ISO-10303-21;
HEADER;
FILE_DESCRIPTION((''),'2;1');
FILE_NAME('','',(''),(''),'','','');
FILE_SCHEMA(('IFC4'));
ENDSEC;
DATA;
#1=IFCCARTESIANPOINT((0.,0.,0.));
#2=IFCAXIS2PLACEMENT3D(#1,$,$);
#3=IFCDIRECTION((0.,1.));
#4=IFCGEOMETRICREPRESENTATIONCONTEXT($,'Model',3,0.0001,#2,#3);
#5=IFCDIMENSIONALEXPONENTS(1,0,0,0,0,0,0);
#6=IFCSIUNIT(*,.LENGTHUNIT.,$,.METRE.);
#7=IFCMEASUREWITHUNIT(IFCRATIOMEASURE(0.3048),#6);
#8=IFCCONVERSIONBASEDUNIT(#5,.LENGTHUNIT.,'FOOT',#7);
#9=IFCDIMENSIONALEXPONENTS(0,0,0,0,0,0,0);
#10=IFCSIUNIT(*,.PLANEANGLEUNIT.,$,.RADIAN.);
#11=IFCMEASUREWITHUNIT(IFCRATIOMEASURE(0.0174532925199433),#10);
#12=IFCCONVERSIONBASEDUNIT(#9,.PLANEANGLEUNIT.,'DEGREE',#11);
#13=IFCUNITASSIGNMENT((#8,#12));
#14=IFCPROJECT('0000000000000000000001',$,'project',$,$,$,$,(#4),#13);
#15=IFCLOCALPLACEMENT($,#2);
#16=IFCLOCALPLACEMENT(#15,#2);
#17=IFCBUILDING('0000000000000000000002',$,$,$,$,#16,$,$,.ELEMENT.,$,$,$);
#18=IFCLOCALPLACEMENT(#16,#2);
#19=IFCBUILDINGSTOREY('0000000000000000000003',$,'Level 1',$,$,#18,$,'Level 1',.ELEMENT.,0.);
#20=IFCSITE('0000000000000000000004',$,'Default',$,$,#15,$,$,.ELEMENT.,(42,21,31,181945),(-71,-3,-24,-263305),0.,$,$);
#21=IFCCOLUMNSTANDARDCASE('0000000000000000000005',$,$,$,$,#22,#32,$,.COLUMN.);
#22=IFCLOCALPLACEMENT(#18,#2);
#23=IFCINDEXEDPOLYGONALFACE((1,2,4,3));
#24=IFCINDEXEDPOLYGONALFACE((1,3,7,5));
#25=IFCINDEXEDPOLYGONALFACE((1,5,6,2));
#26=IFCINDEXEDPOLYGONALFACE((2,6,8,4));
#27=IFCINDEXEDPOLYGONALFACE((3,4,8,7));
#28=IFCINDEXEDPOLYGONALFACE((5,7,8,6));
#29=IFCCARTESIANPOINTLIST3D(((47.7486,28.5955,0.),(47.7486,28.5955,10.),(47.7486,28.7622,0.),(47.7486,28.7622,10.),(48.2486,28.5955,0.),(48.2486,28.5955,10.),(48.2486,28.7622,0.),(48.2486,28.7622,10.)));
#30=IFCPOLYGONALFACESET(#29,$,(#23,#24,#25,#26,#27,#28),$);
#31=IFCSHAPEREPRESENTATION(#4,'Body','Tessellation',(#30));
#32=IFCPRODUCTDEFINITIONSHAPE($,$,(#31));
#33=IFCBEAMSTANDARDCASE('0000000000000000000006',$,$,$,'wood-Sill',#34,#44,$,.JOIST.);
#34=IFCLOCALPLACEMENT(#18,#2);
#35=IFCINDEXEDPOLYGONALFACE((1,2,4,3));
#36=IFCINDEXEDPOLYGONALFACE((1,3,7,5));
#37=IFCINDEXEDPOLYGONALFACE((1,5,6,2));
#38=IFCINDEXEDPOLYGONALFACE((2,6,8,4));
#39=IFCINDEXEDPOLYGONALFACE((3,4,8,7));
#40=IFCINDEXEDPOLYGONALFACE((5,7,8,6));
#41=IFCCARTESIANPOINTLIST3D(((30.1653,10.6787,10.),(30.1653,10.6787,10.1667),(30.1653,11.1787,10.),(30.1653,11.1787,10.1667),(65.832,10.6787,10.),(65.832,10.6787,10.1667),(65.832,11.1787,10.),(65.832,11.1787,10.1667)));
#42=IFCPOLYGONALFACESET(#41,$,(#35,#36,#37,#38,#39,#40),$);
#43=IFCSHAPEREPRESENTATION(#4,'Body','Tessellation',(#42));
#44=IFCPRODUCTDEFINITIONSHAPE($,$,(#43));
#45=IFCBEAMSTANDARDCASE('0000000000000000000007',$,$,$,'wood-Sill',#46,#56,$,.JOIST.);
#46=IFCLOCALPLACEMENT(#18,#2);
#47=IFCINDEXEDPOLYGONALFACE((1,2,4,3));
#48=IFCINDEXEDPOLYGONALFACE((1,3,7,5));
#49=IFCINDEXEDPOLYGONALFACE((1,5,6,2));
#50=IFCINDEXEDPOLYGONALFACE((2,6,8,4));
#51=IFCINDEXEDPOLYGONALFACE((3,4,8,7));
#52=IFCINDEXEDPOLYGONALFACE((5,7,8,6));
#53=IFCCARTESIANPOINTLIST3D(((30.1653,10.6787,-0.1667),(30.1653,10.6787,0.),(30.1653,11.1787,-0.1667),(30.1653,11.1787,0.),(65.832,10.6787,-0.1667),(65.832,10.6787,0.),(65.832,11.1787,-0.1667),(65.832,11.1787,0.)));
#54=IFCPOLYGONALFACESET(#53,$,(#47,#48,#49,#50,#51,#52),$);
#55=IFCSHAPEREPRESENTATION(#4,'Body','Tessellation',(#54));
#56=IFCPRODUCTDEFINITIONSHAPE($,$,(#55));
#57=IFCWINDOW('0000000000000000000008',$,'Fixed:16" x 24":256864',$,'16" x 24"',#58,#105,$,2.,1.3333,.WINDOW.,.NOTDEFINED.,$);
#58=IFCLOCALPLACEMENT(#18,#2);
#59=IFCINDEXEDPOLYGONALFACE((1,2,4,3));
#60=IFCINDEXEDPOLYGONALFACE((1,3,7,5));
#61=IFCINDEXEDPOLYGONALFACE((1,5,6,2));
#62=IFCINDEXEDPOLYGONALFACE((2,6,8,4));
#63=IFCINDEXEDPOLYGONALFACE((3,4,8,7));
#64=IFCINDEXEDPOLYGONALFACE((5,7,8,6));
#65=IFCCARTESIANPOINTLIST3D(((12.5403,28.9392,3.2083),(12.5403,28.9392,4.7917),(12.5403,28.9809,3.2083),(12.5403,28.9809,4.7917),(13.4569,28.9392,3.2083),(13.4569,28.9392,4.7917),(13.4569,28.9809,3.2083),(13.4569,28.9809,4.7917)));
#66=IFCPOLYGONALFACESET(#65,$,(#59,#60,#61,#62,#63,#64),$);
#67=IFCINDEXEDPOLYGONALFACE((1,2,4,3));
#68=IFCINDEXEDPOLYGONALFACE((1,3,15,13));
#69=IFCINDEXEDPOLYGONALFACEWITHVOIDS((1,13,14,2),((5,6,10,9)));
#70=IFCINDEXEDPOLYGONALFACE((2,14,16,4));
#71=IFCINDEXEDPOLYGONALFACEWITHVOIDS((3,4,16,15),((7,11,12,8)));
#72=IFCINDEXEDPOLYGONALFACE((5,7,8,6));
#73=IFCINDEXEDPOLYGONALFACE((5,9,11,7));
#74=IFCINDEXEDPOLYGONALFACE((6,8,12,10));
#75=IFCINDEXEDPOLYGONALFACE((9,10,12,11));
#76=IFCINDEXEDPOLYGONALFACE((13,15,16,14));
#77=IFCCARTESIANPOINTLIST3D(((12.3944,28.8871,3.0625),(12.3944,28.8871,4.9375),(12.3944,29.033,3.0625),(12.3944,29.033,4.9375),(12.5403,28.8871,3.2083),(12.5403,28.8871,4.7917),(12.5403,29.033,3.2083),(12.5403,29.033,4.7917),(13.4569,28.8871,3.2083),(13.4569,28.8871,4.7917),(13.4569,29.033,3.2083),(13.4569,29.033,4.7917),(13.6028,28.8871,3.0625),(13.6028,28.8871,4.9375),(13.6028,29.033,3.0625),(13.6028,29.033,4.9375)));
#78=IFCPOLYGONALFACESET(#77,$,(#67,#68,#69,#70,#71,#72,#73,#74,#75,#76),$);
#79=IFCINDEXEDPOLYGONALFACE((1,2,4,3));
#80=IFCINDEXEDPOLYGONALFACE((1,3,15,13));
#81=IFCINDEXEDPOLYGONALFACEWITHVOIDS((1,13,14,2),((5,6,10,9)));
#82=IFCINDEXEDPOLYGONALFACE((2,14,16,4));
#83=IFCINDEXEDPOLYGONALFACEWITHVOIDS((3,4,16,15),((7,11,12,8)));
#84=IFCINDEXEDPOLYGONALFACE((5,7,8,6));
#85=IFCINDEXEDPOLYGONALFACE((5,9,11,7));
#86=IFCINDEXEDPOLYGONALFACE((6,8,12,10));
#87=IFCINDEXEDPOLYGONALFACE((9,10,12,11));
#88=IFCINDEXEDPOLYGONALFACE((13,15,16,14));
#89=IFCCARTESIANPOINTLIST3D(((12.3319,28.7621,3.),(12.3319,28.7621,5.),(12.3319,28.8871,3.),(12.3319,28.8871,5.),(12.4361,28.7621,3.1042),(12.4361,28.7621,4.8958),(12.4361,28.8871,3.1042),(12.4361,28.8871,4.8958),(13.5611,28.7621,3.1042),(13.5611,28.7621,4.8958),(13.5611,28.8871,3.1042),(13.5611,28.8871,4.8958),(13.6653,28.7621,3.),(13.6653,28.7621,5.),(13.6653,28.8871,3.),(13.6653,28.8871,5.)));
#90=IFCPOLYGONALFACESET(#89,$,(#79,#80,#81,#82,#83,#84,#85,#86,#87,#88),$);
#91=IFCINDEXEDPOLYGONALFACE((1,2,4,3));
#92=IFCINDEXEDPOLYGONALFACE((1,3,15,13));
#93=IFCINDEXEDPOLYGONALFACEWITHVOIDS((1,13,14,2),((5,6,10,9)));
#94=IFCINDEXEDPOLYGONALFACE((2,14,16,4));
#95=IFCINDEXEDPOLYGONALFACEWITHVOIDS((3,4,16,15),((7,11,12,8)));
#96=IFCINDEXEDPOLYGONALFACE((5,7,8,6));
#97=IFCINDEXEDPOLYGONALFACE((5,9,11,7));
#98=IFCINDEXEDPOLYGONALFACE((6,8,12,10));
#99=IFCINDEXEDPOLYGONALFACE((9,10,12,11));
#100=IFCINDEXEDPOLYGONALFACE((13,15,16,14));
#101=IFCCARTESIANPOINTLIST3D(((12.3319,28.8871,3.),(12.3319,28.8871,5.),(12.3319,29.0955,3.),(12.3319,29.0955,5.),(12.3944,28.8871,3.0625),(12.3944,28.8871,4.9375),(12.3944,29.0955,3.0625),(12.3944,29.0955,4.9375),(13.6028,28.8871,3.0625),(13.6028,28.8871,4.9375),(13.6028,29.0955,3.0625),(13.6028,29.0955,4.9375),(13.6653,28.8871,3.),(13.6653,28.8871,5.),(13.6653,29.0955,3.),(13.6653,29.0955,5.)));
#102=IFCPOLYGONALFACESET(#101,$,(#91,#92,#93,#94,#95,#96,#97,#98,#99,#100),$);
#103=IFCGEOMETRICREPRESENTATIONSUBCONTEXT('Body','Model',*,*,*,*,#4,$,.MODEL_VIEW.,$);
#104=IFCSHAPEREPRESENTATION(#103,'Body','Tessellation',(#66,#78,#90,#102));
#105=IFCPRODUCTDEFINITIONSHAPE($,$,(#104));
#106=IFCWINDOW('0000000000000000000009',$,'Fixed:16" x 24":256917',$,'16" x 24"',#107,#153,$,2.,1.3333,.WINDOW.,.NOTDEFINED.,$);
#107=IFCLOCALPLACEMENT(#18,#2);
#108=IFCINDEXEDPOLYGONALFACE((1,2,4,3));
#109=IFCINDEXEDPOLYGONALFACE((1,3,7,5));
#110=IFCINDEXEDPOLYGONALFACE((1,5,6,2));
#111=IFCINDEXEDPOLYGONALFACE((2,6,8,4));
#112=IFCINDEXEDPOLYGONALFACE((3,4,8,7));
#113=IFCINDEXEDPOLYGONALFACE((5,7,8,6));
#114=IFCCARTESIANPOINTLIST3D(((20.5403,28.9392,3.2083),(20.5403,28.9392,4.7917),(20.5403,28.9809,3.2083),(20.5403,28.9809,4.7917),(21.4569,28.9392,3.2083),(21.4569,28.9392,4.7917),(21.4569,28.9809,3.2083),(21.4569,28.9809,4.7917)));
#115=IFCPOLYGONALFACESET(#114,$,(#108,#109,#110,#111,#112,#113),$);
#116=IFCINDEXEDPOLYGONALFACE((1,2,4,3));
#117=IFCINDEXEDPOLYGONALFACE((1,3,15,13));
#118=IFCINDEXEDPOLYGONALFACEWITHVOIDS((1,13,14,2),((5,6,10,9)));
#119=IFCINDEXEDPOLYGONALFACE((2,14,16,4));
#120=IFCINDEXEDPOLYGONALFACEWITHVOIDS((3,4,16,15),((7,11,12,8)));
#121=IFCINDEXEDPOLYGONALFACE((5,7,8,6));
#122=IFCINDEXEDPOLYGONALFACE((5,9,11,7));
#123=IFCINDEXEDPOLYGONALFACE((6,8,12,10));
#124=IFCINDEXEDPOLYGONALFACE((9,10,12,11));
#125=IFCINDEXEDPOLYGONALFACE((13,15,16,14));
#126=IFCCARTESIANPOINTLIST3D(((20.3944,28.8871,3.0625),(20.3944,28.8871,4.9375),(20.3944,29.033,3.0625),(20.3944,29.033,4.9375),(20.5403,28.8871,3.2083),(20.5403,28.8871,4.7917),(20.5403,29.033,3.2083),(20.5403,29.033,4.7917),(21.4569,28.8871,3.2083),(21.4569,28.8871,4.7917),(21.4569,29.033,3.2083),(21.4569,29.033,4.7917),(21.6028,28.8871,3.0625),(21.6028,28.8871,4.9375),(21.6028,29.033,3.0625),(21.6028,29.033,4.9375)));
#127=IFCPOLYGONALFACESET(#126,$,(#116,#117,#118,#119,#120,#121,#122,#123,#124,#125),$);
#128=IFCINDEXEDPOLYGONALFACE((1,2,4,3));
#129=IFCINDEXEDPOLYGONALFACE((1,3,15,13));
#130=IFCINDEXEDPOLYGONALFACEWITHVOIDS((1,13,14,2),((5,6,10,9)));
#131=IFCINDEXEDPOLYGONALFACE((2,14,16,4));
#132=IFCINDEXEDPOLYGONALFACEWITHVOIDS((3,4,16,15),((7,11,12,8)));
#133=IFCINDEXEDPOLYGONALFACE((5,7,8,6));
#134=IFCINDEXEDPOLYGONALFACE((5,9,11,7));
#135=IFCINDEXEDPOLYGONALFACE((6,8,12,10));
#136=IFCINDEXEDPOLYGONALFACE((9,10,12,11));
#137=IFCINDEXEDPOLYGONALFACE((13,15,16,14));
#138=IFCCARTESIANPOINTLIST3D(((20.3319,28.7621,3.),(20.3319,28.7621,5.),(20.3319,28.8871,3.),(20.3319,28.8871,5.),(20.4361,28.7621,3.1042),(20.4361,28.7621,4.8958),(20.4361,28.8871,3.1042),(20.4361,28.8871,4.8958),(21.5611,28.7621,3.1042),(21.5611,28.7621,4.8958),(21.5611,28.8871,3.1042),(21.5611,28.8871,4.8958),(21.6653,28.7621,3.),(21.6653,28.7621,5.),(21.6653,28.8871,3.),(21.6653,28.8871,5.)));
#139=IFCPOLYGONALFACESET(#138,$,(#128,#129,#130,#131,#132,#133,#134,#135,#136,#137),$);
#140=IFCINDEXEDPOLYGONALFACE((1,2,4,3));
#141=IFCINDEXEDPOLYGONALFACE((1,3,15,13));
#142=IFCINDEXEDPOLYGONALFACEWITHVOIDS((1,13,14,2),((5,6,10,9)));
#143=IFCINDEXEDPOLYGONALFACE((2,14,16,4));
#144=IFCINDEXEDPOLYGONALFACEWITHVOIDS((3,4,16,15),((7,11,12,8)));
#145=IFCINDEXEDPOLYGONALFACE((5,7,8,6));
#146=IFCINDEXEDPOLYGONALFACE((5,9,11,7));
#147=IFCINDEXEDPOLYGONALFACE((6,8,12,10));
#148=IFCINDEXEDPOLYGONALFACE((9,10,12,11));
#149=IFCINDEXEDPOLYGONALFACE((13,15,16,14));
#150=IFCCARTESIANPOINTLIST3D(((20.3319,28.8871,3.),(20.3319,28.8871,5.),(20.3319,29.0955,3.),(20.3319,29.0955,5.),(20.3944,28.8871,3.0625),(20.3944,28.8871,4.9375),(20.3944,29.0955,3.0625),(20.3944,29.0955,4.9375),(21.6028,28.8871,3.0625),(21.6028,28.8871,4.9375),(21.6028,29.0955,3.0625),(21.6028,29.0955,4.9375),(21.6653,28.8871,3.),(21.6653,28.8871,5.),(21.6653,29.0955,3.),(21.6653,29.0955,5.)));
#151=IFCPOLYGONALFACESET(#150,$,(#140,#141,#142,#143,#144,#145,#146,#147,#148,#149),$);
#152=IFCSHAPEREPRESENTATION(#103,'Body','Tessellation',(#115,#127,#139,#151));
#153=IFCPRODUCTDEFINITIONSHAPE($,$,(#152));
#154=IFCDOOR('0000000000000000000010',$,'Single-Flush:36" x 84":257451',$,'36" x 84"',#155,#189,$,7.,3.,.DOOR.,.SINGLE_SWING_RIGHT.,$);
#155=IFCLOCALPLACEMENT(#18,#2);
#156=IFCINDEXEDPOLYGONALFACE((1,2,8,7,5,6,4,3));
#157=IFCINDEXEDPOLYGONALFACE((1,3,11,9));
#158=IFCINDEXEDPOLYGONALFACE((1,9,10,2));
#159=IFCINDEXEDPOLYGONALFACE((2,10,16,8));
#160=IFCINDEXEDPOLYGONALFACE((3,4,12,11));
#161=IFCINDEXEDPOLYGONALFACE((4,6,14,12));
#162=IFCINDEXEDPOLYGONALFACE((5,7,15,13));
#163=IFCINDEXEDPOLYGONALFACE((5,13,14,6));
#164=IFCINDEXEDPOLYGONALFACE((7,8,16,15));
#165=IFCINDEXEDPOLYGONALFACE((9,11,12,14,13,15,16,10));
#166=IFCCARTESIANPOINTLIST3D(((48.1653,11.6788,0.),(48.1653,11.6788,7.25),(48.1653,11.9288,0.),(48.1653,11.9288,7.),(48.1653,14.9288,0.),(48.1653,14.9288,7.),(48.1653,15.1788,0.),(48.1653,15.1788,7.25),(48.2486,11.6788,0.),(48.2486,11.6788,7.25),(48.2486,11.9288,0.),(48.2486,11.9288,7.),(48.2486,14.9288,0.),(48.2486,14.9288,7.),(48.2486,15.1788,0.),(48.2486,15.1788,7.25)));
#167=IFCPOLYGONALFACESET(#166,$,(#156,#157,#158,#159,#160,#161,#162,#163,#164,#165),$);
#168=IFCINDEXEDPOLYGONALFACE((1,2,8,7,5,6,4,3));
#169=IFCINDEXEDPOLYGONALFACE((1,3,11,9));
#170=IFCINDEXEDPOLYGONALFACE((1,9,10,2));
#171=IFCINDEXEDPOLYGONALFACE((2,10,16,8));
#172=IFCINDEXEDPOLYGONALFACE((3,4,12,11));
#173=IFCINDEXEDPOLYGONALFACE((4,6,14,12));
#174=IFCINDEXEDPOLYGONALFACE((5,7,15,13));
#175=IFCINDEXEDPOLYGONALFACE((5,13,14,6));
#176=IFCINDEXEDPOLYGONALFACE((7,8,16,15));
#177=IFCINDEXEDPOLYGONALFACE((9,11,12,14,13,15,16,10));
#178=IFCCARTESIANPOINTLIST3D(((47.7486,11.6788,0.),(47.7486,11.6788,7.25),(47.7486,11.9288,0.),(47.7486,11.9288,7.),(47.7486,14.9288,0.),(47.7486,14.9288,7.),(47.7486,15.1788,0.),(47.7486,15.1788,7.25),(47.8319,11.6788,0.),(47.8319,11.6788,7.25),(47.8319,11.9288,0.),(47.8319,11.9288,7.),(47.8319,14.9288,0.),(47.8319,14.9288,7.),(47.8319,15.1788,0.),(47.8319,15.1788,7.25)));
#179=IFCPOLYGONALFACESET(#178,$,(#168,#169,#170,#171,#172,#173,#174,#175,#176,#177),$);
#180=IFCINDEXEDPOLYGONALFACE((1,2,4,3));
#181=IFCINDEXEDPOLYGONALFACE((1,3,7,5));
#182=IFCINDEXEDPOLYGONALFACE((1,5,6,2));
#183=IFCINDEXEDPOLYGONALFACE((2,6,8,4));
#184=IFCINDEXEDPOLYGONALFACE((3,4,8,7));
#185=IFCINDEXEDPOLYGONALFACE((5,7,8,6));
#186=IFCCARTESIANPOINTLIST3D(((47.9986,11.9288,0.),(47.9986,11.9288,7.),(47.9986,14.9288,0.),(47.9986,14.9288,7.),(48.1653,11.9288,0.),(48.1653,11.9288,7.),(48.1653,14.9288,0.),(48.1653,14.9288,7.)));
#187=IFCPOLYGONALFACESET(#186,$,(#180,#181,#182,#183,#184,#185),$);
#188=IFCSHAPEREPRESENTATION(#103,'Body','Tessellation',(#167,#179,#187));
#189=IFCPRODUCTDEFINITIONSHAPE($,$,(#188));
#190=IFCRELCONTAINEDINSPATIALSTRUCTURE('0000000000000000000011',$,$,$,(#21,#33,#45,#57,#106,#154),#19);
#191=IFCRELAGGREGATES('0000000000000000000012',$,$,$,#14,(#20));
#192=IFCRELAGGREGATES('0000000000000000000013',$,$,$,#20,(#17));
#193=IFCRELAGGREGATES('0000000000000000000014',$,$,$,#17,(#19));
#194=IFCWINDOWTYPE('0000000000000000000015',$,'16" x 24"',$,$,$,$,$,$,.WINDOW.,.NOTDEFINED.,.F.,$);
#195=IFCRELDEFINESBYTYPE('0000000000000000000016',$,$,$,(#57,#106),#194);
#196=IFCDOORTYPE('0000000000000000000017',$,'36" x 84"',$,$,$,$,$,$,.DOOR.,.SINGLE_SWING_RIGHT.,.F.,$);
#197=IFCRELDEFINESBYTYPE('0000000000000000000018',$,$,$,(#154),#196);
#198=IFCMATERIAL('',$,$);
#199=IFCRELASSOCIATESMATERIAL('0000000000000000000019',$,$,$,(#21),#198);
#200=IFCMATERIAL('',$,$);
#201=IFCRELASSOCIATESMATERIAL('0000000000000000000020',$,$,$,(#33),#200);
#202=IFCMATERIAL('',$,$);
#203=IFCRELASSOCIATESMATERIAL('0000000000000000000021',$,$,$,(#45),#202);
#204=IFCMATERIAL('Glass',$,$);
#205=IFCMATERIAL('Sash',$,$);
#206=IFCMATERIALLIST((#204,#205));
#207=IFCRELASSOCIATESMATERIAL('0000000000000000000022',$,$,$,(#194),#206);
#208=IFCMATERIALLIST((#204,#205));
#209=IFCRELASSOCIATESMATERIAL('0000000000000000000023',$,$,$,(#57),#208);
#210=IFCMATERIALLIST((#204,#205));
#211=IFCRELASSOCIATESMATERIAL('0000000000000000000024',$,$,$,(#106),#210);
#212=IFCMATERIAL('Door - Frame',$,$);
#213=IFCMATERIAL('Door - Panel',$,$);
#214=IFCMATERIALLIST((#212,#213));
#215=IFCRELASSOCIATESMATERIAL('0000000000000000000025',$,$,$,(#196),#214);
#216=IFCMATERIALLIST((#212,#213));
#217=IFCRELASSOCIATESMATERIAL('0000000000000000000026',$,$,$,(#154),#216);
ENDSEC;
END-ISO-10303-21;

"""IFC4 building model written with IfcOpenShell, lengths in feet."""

from ifc_helpers import new_model, entity, si_unit, converted_unit, direction, frame, frame_2d, origin, origin_2d_with_axis, place, context, subcontext, project, spatial, polyline, rectangle, outline, extrude, source, transform, mapped, material, material_list, type_object, type_shapes, element, save


model = new_model("IFC4")

# Units and contexts
model_context = context("Model", 3, precision=0.0001, world=origin(), true_north=direction((0.0, 1.0)))
body_context = subcontext(model_context, "Body", "Model", "MODEL_VIEW")
ifc_project = project(units=[converted_unit("LENGTHUNIT", "FOOT", entity("IfcRatioMeasure", 0.3048), si_unit("LENGTHUNIT", "METRE"), dimensions=[1, 0, 0, 0, 0, 0, 0]), converted_unit("PLANEANGLEUNIT", "DEGREE", entity("IfcRatioMeasure", 0.0174532925199433), si_unit("PLANEANGLEUNIT", "RADIAN"), dimensions=[0, 0, 0, 0, 0, 0, 0])], contexts=[model_context])

# Site, building, storey
site_placement = place(None, origin())
site = spatial("IfcSite", under=ifc_project, at=site_placement, Name="Default", CompositionType="ELEMENT", RefLatitude=(42, 21, 31, 181945), RefLongitude=(-71, -3, -24, -263305), RefElevation=0.0)
building_placement = place(site_placement, origin())
building = spatial("IfcBuilding", under=site, at=building_placement, CompositionType="ELEMENT")
storey_placement = place(building_placement, origin())
storey = spatial("IfcBuildingStorey", under=building, at=storey_placement, Name="Level 1", LongName="Level 1", CompositionType="ELEMENT", Elevation=0.0)

# Column
placement_1 = place(storey_placement, frame((-0.1681, 28.9288, 0.0)))
ifc_material_1 = material(Name="")
placement_2 = place(storey_placement, frame((47.9986, 28.7621, 0.0), z_axis=(0.0, 0.0, 1.0), x_axis=(0.0, -1.0, 0.0)))
for number, where, z_axis, x_axis in (
    (1, (0.0833, 0.0, 0.0), (0.0, 0.0, 1.0), (1.0, 0.0, 0.0)),
):
    element("IfcColumnStandardCase", number, at=place(placement_2, frame(where, z_axis=z_axis, x_axis=x_axis)), inside=storey, material=ifc_material_1, PredefinedType="COLUMN", context=model_context, shape_type="SweptSolid", body=[
        extrude(rectangle(XDim=0.1667, YDim=0.5), origin(), (0.0, 0.0, 1.0), 10.0),
    ])

# Beams
ifc_material_2 = material(Name="")
beam_1_placement = place(placement_2, frame((17.8334, 0.0, 10.0), z_axis=(0.0, 0.0, 1.0), x_axis=(0.0, -1.0, 0.0)))
element("IfcBeamStandardCase", 2, at=beam_1_placement, inside=storey, material=ifc_material_2, ObjectType="wood-Sill", PredefinedType="JOIST", context=model_context, shape_type="SweptSolid", body=[
    extrude(rectangle(XDim=35.6667, YDim=0.5), origin(), (0.0, 0.0, 1.0), 0.1667),
])
ifc_material_3 = material(Name="")
beam_2_placement = place(placement_2, frame((17.8334, 0.0, -0.1667), z_axis=(0.0, 0.0, 1.0), x_axis=(0.0, -1.0, 0.0)))
element("IfcBeamStandardCase", 3, at=beam_2_placement, inside=storey, material=ifc_material_3, ObjectType="wood-Sill", PredefinedType="JOIST", context=model_context, shape_type="SweptSolid", body=[
    extrude(rectangle(XDim=35.6667, YDim=0.5), origin(), (0.0, 0.0, 1.0), 0.1667),
])

# Windows
ifc_material_4 = material(Name="Glass")
ifc_material_5 = material(Name="Sash")
ifc_material_list_1 = material_list([ifc_material_4, ifc_material_5])
ifc_material_list_2 = material_list([ifc_material_4, ifc_material_5])
window_type = type_object("IfcWindowType", Name="16\" x 24\"", ParameterTakesPrecedence=False, PartitioningType="NOTDEFINED", PredefinedType="WINDOW", material=ifc_material_list_2)
shared_shape_1 = source(origin(), body_context, "Body", "SweptSolid", [
    extrude(rectangle(XDim=0.0417, YDim=0.9167, at=origin_2d_with_axis()), frame((0.6667, 0.1979, 0.2083), z_axis=(0.0, 0.0, 1.0), x_axis=(0.0, 1.0, 0.0)), (0.0, 0.0, 1.0), 1.5833),
    extrude(outline(polyline([(-0.6042, -0.9375), (0.6042, -0.9375), (0.6042, 0.9375), (-0.6042, 0.9375), (-0.6042, -0.9375)]), holes=[polyline([(-0.4583, -0.7917), (-0.4583, 0.7917), (0.4583, 0.7917), (0.4583, -0.7917), (-0.4583, -0.7917)])]), frame((0.6667, 0.125, 1.0), z_axis=(0.0, 1.0, 0.0), x_axis=(1.0, 0.0, 0.0)), (0.0, 0.0, 1.0), 0.1458),
    extrude(outline(polyline([(-0.6667, -1.0), (0.6667, -1.0), (0.6667, 1.0), (-0.6667, 1.0), (-0.6667, -1.0)]), holes=[polyline([(-0.5625, -0.8958), (-0.5625, 0.8958), (0.5625, 0.8958), (0.5625, -0.8958), (-0.5625, -0.8958)])]), frame((0.6667, 0.0, 1.0), z_axis=(0.0, 1.0, 0.0), x_axis=(1.0, 0.0, 0.0)), (0.0, 0.0, 1.0), 0.125),
    extrude(outline(polyline([(-1.0, -0.6667), (1.0, -0.6667), (1.0, 0.6667), (-1.0, 0.6667), (-1.0, -0.6667)]), holes=[polyline([(-0.9375, -0.6042), (-0.9375, 0.6042), (0.9375, 0.6042), (0.9375, -0.6042), (-0.9375, -0.6042)])]), frame((0.6667, 0.125, 1.0), z_axis=(0.0, 1.0, 0.0), x_axis=(0.0, 0.0, -1.0)), (0.0, 0.0, 1.0), 0.2083),
])
type_shapes(window_type, [shared_shape_1])
placement_3 = place(placement_1, frame((12.5, -0.1667, 3.0)))
window_1_placement = place(placement_3, origin())
element("IfcWindow", 4, at=window_1_placement, inside=storey, type_object=window_type, material=ifc_material_list_1, Name="Fixed:16\" x 24\":256864", ObjectType="16\" x 24\"", OverallHeight=2.0, OverallWidth=1.3333, PartitioningType="NOTDEFINED", PredefinedType="WINDOW", context=body_context, shape_type="MappedRepresentation", body=[
    mapped(shared_shape_1, transform((0.0, 0.0, 0.0), scale=1.0)),
])
ifc_material_list_3 = material_list([ifc_material_4, ifc_material_5])
placement_4 = place(placement_1, frame((20.5, -0.1667, 3.0)))
window_2_placement = place(placement_4, origin())
element("IfcWindow", 5, at=window_2_placement, inside=storey, type_object=window_type, material=ifc_material_list_3, Name="Fixed:16\" x 24\":256917", ObjectType="16\" x 24\"", OverallHeight=2.0, OverallWidth=1.3333, PartitioningType="NOTDEFINED", PredefinedType="WINDOW", context=body_context, shape_type="MappedRepresentation", body=[
    mapped(shared_shape_1, transform((0.0, 0.0, 0.0), scale=1.0)),
])

# Door
ifc_material_6 = material(Name="Door - Frame")
ifc_material_7 = material(Name="Door - Panel")
ifc_material_list_4 = material_list([ifc_material_6, ifc_material_7])
ifc_material_list_5 = material_list([ifc_material_6, ifc_material_7])
door_type = type_object("IfcDoorType", Name="36\" x 84\"", OperationType="SINGLE_SWING_RIGHT", ParameterTakesPrecedence=False, PredefinedType="DOOR", material=ifc_material_list_5)
shared_shape_2 = source(origin(), body_context, "Body", "SweptSolid", [
    extrude(outline(polyline([(-1.75, -3.6875), (1.75, -3.6875), (1.75, 3.5625), (1.5, 3.5625), (1.5, -3.4375), (-1.5, -3.4375), (-1.5, 3.5625), (-1.75, 3.5625), (-1.75, -3.6875)])), frame((1.5, 0.3333, 3.5625), z_axis=(0.0, 1.0, 0.0), x_axis=(1.0, 0.0, 0.0)), (0.0, 0.0, 1.0), 0.0833),
    extrude(outline(polyline([(-3.6875, -1.75), (3.5625, -1.75), (3.5625, -1.5), (-3.4375, -1.5), (-3.4375, 1.5), (3.5625, 1.5), (3.5625, 1.75), (-3.6875, 1.75), (-3.6875, -1.75)])), frame((1.5, -0.0833, 3.5625), z_axis=(0.0, 1.0, 0.0), x_axis=(0.0, 0.0, -1.0)), (0.0, 0.0, 1.0), 0.0833),
    extrude(rectangle(XDim=0.1667, YDim=3.0, at=frame_2d((0.0, 0.0), x_axis=(1.0, 0.0))), frame((1.5, 0.25, 0.0), z_axis=(0.0, 0.0, 1.0), x_axis=(0.0, 1.0, 0.0)), (0.0, 0.0, 1.0), 7.0),
])
type_shapes(door_type, [shared_shape_2])
placement_5 = place(placement_2, frame((13.8333, -0.1667, 0.0)))
door_placement = place(placement_5, origin())
element("IfcDoor", 6, at=door_placement, inside=storey, type_object=door_type, material=ifc_material_list_4, Name="Single-Flush:36\" x 84\":257451", ObjectType="36\" x 84\"", OperationType="SINGLE_SWING_RIGHT", OverallHeight=7.0, OverallWidth=3.0, PredefinedType="DOOR", context=body_context, shape_type="MappedRepresentation", body=[
    mapped(shared_shape_2, transform((0.0, 0.0, 0.0), scale=1.0)),
])

save(model, "model.ifc")
